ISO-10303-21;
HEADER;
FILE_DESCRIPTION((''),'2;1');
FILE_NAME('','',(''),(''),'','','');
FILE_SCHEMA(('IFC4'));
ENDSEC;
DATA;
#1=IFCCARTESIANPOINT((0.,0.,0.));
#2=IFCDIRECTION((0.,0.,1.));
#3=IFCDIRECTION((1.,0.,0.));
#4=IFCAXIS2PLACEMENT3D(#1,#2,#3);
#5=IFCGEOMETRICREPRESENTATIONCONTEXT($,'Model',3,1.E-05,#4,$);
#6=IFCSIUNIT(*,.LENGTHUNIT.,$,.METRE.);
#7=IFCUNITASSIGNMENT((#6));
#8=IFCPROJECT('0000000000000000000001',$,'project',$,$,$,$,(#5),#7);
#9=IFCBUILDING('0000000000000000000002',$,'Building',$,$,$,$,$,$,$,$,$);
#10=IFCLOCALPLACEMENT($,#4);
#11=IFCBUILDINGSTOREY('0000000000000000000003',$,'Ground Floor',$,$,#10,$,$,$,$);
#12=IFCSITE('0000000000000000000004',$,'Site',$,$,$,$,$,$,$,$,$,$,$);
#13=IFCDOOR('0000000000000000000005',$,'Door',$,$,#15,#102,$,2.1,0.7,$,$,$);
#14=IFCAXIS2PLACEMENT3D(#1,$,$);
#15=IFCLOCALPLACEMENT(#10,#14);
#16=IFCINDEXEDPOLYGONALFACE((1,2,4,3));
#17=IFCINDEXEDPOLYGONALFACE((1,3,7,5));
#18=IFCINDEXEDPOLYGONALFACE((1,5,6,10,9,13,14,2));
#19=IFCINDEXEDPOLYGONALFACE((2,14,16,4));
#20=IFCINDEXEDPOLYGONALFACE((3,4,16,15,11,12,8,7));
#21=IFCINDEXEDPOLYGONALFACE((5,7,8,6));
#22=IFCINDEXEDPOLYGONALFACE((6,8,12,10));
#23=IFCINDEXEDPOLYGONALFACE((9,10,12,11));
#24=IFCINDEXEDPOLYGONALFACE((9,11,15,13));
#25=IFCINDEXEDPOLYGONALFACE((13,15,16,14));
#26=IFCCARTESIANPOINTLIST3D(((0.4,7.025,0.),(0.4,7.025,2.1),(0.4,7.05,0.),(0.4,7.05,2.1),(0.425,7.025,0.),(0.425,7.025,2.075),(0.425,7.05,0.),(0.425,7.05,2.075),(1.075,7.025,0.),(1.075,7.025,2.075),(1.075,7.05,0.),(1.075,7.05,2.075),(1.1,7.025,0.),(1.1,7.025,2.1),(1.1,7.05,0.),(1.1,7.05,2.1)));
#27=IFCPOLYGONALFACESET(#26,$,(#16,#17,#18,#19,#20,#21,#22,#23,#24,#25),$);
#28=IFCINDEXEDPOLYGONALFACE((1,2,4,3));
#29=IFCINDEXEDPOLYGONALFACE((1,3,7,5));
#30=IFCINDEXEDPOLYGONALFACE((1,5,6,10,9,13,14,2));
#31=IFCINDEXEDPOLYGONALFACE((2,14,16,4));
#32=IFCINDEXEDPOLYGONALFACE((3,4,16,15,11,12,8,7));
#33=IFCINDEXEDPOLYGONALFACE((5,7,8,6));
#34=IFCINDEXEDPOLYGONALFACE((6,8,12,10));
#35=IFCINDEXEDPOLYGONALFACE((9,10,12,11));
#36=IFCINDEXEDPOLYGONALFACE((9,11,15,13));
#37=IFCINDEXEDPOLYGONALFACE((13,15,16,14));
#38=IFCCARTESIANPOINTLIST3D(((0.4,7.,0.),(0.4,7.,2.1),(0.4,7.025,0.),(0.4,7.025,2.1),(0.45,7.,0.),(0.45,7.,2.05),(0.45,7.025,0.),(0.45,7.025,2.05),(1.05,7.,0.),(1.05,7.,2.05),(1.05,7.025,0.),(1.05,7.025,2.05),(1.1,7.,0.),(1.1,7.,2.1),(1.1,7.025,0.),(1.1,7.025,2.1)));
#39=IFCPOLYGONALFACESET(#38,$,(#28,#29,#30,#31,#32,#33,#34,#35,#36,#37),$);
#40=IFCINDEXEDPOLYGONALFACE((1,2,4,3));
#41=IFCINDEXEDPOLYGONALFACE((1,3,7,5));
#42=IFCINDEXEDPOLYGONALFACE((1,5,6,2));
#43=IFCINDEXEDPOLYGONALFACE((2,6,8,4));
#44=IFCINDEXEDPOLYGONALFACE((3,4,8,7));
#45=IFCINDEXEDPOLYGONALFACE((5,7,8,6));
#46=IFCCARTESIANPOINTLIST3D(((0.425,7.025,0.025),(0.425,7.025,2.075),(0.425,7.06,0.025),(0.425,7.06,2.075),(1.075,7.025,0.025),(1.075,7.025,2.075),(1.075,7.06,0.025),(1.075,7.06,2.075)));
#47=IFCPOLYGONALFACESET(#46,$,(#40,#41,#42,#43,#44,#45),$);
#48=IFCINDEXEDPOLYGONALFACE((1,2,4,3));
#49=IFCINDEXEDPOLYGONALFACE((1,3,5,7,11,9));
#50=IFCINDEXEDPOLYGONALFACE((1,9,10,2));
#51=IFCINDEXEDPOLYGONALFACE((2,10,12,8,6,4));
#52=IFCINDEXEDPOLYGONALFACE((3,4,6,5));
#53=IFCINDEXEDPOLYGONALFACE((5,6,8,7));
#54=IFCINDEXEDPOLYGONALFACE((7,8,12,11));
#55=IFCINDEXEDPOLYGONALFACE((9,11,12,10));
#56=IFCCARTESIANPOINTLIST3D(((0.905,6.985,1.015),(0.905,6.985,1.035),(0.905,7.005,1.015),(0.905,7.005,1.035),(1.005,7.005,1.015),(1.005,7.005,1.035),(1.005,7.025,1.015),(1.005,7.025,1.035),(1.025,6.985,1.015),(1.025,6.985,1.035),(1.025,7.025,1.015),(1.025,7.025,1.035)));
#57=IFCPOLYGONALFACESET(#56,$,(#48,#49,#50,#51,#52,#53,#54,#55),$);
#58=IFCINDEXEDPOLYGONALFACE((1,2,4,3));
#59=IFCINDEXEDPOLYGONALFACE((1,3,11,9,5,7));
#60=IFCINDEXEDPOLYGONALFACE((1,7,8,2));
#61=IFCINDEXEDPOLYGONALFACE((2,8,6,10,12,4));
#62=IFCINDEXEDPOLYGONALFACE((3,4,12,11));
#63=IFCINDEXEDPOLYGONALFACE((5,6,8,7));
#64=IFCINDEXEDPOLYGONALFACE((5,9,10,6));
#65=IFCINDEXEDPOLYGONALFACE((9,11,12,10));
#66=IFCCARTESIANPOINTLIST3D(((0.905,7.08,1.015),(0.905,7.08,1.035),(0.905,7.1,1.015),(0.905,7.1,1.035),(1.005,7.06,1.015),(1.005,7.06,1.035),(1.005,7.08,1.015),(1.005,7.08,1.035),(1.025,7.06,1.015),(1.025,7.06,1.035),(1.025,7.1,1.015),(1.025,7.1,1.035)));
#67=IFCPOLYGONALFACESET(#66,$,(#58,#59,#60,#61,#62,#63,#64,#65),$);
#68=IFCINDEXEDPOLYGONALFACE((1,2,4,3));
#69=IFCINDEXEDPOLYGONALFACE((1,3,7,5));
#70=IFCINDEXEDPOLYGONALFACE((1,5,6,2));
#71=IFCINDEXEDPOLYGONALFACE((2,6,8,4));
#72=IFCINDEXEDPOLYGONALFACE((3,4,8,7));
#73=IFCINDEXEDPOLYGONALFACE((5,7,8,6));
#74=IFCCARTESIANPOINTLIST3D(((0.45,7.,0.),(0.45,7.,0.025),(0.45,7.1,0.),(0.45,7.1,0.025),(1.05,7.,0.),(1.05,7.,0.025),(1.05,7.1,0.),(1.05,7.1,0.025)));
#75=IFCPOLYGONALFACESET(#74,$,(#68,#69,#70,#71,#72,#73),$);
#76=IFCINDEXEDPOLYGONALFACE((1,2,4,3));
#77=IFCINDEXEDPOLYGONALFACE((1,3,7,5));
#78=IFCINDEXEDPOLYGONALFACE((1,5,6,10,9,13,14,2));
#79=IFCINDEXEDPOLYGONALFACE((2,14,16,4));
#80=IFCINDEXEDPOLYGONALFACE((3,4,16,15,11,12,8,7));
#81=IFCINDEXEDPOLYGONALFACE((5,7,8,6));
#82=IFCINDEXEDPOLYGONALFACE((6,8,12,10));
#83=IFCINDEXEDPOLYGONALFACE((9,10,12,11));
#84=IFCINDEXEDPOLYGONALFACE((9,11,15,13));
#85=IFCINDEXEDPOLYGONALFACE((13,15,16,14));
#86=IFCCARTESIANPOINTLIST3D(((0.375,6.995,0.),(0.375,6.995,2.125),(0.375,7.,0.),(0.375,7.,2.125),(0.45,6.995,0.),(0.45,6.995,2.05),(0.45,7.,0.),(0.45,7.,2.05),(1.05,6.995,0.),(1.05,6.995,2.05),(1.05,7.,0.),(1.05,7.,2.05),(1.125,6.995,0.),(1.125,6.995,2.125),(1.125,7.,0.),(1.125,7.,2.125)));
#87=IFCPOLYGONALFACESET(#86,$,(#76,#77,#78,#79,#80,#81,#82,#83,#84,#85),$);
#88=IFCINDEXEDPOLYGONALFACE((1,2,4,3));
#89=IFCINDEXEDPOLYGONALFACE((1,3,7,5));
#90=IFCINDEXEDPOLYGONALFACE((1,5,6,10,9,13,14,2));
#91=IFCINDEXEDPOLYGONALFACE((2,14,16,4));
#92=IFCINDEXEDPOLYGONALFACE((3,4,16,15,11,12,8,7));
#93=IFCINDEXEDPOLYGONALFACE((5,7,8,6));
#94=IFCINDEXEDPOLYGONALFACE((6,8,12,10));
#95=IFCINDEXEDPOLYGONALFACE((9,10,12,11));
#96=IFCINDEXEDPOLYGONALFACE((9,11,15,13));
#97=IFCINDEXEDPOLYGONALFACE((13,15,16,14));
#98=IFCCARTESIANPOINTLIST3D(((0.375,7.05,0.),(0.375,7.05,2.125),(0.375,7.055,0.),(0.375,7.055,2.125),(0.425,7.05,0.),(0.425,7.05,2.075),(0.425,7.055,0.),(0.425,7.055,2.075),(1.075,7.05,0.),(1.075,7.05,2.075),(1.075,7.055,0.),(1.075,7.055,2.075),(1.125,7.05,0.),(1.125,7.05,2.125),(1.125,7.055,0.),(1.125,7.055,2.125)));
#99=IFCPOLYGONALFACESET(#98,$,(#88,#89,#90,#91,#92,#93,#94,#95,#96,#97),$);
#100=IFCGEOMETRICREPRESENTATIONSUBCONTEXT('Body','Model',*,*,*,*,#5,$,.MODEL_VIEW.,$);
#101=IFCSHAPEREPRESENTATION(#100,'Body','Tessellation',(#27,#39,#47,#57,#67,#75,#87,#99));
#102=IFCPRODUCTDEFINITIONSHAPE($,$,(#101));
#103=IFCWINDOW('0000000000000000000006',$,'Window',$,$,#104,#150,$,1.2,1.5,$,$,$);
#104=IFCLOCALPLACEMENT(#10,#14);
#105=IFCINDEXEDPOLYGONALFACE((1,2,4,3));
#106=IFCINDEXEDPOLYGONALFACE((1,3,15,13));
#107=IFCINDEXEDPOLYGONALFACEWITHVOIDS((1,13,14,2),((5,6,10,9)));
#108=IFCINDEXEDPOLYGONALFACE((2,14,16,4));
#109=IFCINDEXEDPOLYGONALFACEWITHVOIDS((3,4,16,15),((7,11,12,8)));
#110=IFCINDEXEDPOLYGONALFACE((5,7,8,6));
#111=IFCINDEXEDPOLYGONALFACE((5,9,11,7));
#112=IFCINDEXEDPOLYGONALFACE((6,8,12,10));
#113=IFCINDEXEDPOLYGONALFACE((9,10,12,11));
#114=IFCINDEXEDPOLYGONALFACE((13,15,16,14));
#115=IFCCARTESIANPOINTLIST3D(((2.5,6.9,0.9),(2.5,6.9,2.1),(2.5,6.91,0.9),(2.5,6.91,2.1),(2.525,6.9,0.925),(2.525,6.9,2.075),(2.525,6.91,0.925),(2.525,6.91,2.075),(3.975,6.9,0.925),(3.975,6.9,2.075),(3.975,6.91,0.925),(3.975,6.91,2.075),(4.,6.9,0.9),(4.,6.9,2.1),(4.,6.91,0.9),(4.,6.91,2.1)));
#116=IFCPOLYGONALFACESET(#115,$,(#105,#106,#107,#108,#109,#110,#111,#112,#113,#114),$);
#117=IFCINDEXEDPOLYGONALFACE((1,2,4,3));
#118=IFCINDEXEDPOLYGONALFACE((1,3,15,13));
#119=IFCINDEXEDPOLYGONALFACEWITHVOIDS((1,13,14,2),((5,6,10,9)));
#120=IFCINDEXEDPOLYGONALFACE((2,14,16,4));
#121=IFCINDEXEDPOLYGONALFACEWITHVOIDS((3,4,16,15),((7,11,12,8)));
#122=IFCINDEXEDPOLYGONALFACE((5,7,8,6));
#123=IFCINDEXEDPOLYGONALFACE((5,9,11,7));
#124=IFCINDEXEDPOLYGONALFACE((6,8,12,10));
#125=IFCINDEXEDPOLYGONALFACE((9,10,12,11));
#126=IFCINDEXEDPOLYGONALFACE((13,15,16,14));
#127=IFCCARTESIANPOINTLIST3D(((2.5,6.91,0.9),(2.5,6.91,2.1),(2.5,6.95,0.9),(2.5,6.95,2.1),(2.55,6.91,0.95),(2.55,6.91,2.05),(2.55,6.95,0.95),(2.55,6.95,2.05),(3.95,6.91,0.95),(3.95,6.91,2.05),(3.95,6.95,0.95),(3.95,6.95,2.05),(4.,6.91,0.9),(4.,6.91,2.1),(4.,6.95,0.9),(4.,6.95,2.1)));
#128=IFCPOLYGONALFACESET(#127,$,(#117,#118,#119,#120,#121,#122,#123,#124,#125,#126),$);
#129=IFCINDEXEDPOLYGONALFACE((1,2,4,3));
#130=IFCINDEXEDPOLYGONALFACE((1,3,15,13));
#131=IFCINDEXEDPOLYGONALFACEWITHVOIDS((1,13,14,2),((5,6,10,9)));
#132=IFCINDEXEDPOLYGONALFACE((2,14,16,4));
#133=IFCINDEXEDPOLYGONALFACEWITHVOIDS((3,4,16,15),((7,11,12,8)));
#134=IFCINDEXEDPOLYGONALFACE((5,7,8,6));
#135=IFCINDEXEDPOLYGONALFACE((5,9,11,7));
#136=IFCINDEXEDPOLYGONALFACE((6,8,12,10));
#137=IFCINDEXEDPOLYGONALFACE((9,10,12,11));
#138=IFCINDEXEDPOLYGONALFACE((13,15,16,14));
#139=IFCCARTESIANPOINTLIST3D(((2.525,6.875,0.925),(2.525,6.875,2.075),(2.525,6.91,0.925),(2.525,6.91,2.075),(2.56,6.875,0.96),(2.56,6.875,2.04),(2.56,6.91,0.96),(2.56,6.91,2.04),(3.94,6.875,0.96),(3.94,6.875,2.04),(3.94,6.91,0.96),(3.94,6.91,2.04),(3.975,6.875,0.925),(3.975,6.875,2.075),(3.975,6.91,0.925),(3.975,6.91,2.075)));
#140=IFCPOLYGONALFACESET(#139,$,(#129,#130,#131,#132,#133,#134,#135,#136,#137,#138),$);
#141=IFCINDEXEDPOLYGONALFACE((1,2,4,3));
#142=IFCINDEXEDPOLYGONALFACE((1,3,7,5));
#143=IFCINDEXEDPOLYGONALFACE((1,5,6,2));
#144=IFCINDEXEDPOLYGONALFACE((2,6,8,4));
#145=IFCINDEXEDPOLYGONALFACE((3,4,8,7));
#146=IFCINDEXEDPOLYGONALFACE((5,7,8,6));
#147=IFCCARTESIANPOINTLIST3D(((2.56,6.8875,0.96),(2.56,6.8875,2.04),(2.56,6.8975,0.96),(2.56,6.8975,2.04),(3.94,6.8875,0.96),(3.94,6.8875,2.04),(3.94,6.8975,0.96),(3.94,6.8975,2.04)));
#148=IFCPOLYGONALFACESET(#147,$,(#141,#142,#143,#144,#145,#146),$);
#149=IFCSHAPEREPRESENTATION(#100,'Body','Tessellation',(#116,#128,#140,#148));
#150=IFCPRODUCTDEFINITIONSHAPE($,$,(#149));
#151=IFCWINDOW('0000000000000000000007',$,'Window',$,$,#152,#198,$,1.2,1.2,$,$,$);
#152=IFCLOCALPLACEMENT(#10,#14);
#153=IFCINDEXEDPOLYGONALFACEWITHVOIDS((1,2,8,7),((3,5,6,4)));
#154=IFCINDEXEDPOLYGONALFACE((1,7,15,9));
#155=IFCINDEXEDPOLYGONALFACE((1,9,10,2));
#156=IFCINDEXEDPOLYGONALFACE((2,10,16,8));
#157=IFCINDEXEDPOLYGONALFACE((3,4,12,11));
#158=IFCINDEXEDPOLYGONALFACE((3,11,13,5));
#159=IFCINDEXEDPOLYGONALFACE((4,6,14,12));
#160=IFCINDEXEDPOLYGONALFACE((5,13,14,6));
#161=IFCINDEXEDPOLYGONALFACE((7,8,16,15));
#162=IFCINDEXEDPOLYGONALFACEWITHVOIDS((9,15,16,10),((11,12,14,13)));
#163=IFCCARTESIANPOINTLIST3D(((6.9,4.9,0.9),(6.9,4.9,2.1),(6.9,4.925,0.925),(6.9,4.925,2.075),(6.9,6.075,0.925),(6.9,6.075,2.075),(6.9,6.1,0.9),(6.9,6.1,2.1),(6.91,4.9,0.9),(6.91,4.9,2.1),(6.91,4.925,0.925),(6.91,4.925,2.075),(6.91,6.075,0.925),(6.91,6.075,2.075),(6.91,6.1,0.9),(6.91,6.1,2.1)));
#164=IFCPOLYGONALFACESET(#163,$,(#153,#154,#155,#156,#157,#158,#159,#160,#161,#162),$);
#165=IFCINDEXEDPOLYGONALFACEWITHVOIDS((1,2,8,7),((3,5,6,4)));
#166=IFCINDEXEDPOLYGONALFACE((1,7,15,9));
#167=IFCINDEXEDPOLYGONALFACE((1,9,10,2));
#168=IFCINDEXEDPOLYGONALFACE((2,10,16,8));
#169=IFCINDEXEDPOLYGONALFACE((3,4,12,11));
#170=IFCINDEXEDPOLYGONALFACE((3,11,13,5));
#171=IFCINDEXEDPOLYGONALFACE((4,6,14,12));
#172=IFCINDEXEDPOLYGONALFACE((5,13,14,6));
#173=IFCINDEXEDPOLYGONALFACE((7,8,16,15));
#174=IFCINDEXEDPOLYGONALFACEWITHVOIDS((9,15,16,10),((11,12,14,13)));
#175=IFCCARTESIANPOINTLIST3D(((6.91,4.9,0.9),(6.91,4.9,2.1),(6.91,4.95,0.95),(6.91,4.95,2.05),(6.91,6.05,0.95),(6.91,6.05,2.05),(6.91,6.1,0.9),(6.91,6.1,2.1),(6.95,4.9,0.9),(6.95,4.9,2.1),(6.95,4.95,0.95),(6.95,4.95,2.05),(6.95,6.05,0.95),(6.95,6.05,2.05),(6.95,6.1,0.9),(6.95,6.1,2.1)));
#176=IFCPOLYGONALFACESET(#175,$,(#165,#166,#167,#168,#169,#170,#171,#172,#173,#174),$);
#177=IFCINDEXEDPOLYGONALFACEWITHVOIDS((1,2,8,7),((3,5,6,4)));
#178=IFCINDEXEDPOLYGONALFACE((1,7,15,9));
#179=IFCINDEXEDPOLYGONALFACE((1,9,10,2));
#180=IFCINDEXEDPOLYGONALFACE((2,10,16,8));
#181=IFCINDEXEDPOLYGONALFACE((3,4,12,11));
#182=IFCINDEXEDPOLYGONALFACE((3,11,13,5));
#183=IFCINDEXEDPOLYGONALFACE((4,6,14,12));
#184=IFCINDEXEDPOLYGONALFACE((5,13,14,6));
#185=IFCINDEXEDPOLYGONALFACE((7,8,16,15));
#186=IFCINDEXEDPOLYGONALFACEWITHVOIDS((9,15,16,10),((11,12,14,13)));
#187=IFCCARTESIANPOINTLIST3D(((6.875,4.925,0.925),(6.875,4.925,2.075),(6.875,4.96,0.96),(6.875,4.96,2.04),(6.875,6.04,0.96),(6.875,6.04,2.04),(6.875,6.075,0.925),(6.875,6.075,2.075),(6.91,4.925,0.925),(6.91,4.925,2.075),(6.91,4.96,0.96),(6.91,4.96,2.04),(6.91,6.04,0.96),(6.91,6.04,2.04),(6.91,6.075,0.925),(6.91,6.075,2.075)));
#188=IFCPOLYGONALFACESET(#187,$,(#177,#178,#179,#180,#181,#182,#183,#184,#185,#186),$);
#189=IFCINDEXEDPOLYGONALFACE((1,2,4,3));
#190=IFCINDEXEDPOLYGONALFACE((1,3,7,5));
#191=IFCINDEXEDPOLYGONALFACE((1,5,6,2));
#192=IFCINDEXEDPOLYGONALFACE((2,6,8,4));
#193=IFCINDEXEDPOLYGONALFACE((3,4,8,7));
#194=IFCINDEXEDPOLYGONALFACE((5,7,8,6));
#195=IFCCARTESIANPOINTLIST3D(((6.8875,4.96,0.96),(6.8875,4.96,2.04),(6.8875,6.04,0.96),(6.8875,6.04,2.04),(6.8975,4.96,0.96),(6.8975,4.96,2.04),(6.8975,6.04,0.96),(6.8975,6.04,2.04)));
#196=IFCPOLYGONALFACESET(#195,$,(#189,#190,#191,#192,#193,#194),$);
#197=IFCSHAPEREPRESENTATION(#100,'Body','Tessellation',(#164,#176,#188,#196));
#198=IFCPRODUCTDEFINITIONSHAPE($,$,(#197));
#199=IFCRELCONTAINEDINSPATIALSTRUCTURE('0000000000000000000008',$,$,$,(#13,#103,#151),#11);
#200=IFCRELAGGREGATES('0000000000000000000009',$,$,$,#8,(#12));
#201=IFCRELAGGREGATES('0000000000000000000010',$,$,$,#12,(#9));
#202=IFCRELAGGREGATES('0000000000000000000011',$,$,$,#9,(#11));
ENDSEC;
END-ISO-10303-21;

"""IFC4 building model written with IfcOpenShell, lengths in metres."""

from ifc_helpers import new_model, si_unit, frame, origin_with_axes, place, context, subcontext, project, spatial, line, indexed_curve, outline, extrude, element, save


model = new_model("IFC4")

# Units and contexts
model_context = context("Model", 3, precision=1e-05, world=origin_with_axes())
body_context = subcontext(model_context, "Body", "Model", "MODEL_VIEW")
ifc_project = project(units=[si_unit("LENGTHUNIT", "METRE")], contexts=[model_context])

# Site, building, storey
site = spatial("IfcSite", under=ifc_project, Name="Site")
building = spatial("IfcBuilding", under=site, Name="Building")
storey_placement = place(None, origin_with_axes())
storey = spatial("IfcBuildingStorey", under=building, at=storey_placement, Name="Ground Floor")

# Door
door_1_placement = place(storey_placement, frame((0.4, 7.0, 0.0), z_axis=(0.0, 0.0, 1.0), x_axis=(1.0, 0.0, 0.0)))
element("IfcDoor", 1, at=door_1_placement, inside=storey, Name="Door", OverallHeight=2.1, OverallWidth=0.7, context=body_context, shape_type="SweptSolid", body=[
    extrude(outline(indexed_curve([(0.0, 0.0), (0.0, 2.1), (0.7, 2.1), (0.7, 0.0), (0.675, 0.0), (0.675, 2.075), (0.025, 2.075), (0.025, 0.0)], segments=[line(1, 2, 3, 4, 5, 6, 7, 8, 1)])), frame((0.0, 0.025, 0.0), z_axis=(0.0, -1.0, 0.0), x_axis=(1.0, 0.0, 0.0)), (0.0, 0.0, -1.0), 0.025),
    extrude(outline(indexed_curve([(0.0, 0.0), (0.0, 2.1), (0.7, 2.1), (0.7, 0.0), (0.65, 0.0), (0.65, 2.05), (0.05, 2.05), (0.05, 0.0)], segments=[line(1, 2, 3, 4, 5, 6, 7, 8, 1)])), frame((0.0, 0.0, 0.0), z_axis=(0.0, -1.0, 0.0), x_axis=(1.0, 0.0, 0.0)), (0.0, 0.0, -1.0), 0.025),
    extrude(outline(indexed_curve([(0.0, 0.0), (0.65, 0.0), (0.65, 0.035), (0.0, 0.035)], segments=[line(1, 2, 3, 4, 1)])), frame((0.025, 0.025, 0.025), z_axis=(0.0, 0.0, 1.0), x_axis=(1.0, 0.0, 0.0)), (0.0, 0.0, 1.0), 2.05),
    extrude(outline(indexed_curve([(0.0, 0.0), (0.0, -0.04), (-0.12, -0.04), (-0.12, -0.02), (-0.02, -0.02), (-0.02, 0.0)], segments=[line(1, 2, 3, 4, 5, 6, 1)])), frame((0.625, 0.025, 1.015), z_axis=(0.0, 0.0, 1.0), x_axis=(1.0, 0.0, 0.0)), (0.0, 0.0, 1.0), 0.02),
    extrude(outline(indexed_curve([(0.0, 0.0), (0.0, 0.04), (-0.12, 0.04), (-0.12, 0.02), (-0.02, 0.02), (-0.02, 0.0)], segments=[line(1, 2, 3, 4, 5, 6, 1)])), frame((0.625, 0.06, 1.015), z_axis=(0.0, 0.0, 1.0), x_axis=(1.0, 0.0, 0.0)), (0.0, 0.0, 1.0), 0.02),
    extrude(outline(indexed_curve([(0.0, 0.0), (0.6, 0.0), (0.6, 0.1), (0.0, 0.1)], segments=[line(1, 2, 3, 4, 1)])), frame((0.05, 0.0, 0.0), z_axis=(0.0, 0.0, 1.0), x_axis=(1.0, 0.0, 0.0)), (0.0, 0.0, 1.0), 0.025),
    extrude(outline(indexed_curve([(0.0, 0.0), (0.0, 2.125), (0.75, 2.125), (0.75, 0.0), (0.675, 0.0), (0.675, 2.05), (0.075, 2.05), (0.075, 0.0)], segments=[line(1, 2, 3, 4, 5, 6, 7, 8, 1)])), frame((-0.025, -0.005, 0.0), z_axis=(0.0, -1.0, 0.0), x_axis=(1.0, 0.0, 0.0)), (0.0, 0.0, -1.0), 0.005),
    extrude(outline(indexed_curve([(0.0, 0.0), (0.0, 2.125), (0.75, 2.125), (0.75, 0.0), (0.7, 0.0), (0.7, 2.075), (0.05, 2.075), (0.05, 0.0)], segments=[line(1, 2, 3, 4, 5, 6, 7, 8, 1)])), frame((-0.025, 0.05, 0.0), z_axis=(0.0, -1.0, 0.0), x_axis=(1.0, 0.0, 0.0)), (0.0, 0.0, -1.0), 0.005),
])

# Windows
window_1_placement = place(storey_placement, frame((4.0, 7.0, 0.9), z_axis=(0.0, 0.0, 1.0), x_axis=(-1.0, 0.0, 0.0)))
element("IfcWindow", 2, at=window_1_placement, inside=storey, Name="Window", OverallHeight=1.2, OverallWidth=1.5, context=body_context, shape_type="SweptSolid", body=[
    extrude(outline(indexed_curve([(0.0, 0.0), (1.5, 0.0), (1.5, 1.2), (0.0, 1.2)], segments=[line(1, 2, 3, 4, 1)]), holes=[indexed_curve([(0.025, 0.025), (1.475, 0.025), (1.475, 1.175), (0.025, 1.175)], segments=[line(1, 2, 3, 4, 1)])]), frame((0.0, 0.09, 0.0), z_axis=(0.0, -1.0, 0.0), x_axis=(1.0, 0.0, 0.0)), (0.0, 0.0, -1.0), 0.01),
    extrude(outline(indexed_curve([(0.0, 0.0), (1.5, 0.0), (1.5, 1.2), (0.0, 1.2)], segments=[line(1, 2, 3, 4, 1)]), holes=[indexed_curve([(0.05, 0.05), (1.45, 0.05), (1.45, 1.15), (0.05, 1.15)], segments=[line(1, 2, 3, 4, 1)])]), frame((0.0, 0.05, 0.0), z_axis=(0.0, -1.0, 0.0), x_axis=(1.0, 0.0, 0.0)), (0.0, 0.0, -1.0), 0.04),
    extrude(outline(indexed_curve([(0.0, 0.0), (1.45, 0.0), (1.45, 1.15), (0.0, 1.15)], segments=[line(1, 2, 3, 4, 1)]), holes=[indexed_curve([(0.035, 0.035), (1.415, 0.035), (1.415, 1.115), (0.035, 1.115)], segments=[line(1, 2, 3, 4, 1)])]), frame((0.025, 0.09, 0.025), z_axis=(0.0, -1.0, 0.0), x_axis=(1.0, 0.0, 0.0)), (0.0, 0.0, -1.0), 0.035),
    extrude(outline(indexed_curve([(0.035, 0.035), (1.415, 0.035), (1.415, 1.115), (0.035, 1.115)], segments=[line(1, 2, 3, 4, 1)])), frame((0.025, 0.1025, 0.025), z_axis=(0.0, -1.0, 0.0), x_axis=(1.0, 0.0, 0.0)), (0.0, 0.0, -1.0), 0.01),
])
window_2_placement = place(storey_placement, frame((7.0, 4.9, 0.9), z_axis=(0.0, 0.0, 1.0), x_axis=(0.0, 1.0, 0.0)))
element("IfcWindow", 3, at=window_2_placement, inside=storey, Name="Window", OverallHeight=1.2, OverallWidth=1.2, context=body_context, shape_type="SweptSolid", body=[
    extrude(outline(indexed_curve([(0.0, 0.0), (1.2, 0.0), (1.2, 1.2), (0.0, 1.2)], segments=[line(1, 2, 3, 4, 1)]), holes=[indexed_curve([(0.025, 0.025), (1.175, 0.025), (1.175, 1.175), (0.025, 1.175)], segments=[line(1, 2, 3, 4, 1)])]), frame((0.0, 0.09, 0.0), z_axis=(0.0, -1.0, 0.0), x_axis=(1.0, 0.0, 0.0)), (0.0, 0.0, -1.0), 0.01),
    extrude(outline(indexed_curve([(0.0, 0.0), (1.2, 0.0), (1.2, 1.2), (0.0, 1.2)], segments=[line(1, 2, 3, 4, 1)]), holes=[indexed_curve([(0.05, 0.05), (1.15, 0.05), (1.15, 1.15), (0.05, 1.15)], segments=[line(1, 2, 3, 4, 1)])]), frame((0.0, 0.05, 0.0), z_axis=(0.0, -1.0, 0.0), x_axis=(1.0, 0.0, 0.0)), (0.0, 0.0, -1.0), 0.04),
    extrude(outline(indexed_curve([(0.0, 0.0), (1.15, 0.0), (1.15, 1.15), (0.0, 1.15)], segments=[line(1, 2, 3, 4, 1)]), holes=[indexed_curve([(0.035, 0.035), (1.115, 0.035), (1.115, 1.115), (0.035, 1.115)], segments=[line(1, 2, 3, 4, 1)])]), frame((0.025, 0.09, 0.025), z_axis=(0.0, -1.0, 0.0), x_axis=(1.0, 0.0, 0.0)), (0.0, 0.0, -1.0), 0.035),
    extrude(outline(indexed_curve([(0.035, 0.035), (1.115, 0.035), (1.115, 1.115), (0.035, 1.115)], segments=[line(1, 2, 3, 4, 1)])), frame((0.025, 0.1025, 0.025), z_axis=(0.0, -1.0, 0.0), x_axis=(1.0, 0.0, 0.0)), (0.0, 0.0, -1.0), 0.01),
])

save(model, "model.ifc")
